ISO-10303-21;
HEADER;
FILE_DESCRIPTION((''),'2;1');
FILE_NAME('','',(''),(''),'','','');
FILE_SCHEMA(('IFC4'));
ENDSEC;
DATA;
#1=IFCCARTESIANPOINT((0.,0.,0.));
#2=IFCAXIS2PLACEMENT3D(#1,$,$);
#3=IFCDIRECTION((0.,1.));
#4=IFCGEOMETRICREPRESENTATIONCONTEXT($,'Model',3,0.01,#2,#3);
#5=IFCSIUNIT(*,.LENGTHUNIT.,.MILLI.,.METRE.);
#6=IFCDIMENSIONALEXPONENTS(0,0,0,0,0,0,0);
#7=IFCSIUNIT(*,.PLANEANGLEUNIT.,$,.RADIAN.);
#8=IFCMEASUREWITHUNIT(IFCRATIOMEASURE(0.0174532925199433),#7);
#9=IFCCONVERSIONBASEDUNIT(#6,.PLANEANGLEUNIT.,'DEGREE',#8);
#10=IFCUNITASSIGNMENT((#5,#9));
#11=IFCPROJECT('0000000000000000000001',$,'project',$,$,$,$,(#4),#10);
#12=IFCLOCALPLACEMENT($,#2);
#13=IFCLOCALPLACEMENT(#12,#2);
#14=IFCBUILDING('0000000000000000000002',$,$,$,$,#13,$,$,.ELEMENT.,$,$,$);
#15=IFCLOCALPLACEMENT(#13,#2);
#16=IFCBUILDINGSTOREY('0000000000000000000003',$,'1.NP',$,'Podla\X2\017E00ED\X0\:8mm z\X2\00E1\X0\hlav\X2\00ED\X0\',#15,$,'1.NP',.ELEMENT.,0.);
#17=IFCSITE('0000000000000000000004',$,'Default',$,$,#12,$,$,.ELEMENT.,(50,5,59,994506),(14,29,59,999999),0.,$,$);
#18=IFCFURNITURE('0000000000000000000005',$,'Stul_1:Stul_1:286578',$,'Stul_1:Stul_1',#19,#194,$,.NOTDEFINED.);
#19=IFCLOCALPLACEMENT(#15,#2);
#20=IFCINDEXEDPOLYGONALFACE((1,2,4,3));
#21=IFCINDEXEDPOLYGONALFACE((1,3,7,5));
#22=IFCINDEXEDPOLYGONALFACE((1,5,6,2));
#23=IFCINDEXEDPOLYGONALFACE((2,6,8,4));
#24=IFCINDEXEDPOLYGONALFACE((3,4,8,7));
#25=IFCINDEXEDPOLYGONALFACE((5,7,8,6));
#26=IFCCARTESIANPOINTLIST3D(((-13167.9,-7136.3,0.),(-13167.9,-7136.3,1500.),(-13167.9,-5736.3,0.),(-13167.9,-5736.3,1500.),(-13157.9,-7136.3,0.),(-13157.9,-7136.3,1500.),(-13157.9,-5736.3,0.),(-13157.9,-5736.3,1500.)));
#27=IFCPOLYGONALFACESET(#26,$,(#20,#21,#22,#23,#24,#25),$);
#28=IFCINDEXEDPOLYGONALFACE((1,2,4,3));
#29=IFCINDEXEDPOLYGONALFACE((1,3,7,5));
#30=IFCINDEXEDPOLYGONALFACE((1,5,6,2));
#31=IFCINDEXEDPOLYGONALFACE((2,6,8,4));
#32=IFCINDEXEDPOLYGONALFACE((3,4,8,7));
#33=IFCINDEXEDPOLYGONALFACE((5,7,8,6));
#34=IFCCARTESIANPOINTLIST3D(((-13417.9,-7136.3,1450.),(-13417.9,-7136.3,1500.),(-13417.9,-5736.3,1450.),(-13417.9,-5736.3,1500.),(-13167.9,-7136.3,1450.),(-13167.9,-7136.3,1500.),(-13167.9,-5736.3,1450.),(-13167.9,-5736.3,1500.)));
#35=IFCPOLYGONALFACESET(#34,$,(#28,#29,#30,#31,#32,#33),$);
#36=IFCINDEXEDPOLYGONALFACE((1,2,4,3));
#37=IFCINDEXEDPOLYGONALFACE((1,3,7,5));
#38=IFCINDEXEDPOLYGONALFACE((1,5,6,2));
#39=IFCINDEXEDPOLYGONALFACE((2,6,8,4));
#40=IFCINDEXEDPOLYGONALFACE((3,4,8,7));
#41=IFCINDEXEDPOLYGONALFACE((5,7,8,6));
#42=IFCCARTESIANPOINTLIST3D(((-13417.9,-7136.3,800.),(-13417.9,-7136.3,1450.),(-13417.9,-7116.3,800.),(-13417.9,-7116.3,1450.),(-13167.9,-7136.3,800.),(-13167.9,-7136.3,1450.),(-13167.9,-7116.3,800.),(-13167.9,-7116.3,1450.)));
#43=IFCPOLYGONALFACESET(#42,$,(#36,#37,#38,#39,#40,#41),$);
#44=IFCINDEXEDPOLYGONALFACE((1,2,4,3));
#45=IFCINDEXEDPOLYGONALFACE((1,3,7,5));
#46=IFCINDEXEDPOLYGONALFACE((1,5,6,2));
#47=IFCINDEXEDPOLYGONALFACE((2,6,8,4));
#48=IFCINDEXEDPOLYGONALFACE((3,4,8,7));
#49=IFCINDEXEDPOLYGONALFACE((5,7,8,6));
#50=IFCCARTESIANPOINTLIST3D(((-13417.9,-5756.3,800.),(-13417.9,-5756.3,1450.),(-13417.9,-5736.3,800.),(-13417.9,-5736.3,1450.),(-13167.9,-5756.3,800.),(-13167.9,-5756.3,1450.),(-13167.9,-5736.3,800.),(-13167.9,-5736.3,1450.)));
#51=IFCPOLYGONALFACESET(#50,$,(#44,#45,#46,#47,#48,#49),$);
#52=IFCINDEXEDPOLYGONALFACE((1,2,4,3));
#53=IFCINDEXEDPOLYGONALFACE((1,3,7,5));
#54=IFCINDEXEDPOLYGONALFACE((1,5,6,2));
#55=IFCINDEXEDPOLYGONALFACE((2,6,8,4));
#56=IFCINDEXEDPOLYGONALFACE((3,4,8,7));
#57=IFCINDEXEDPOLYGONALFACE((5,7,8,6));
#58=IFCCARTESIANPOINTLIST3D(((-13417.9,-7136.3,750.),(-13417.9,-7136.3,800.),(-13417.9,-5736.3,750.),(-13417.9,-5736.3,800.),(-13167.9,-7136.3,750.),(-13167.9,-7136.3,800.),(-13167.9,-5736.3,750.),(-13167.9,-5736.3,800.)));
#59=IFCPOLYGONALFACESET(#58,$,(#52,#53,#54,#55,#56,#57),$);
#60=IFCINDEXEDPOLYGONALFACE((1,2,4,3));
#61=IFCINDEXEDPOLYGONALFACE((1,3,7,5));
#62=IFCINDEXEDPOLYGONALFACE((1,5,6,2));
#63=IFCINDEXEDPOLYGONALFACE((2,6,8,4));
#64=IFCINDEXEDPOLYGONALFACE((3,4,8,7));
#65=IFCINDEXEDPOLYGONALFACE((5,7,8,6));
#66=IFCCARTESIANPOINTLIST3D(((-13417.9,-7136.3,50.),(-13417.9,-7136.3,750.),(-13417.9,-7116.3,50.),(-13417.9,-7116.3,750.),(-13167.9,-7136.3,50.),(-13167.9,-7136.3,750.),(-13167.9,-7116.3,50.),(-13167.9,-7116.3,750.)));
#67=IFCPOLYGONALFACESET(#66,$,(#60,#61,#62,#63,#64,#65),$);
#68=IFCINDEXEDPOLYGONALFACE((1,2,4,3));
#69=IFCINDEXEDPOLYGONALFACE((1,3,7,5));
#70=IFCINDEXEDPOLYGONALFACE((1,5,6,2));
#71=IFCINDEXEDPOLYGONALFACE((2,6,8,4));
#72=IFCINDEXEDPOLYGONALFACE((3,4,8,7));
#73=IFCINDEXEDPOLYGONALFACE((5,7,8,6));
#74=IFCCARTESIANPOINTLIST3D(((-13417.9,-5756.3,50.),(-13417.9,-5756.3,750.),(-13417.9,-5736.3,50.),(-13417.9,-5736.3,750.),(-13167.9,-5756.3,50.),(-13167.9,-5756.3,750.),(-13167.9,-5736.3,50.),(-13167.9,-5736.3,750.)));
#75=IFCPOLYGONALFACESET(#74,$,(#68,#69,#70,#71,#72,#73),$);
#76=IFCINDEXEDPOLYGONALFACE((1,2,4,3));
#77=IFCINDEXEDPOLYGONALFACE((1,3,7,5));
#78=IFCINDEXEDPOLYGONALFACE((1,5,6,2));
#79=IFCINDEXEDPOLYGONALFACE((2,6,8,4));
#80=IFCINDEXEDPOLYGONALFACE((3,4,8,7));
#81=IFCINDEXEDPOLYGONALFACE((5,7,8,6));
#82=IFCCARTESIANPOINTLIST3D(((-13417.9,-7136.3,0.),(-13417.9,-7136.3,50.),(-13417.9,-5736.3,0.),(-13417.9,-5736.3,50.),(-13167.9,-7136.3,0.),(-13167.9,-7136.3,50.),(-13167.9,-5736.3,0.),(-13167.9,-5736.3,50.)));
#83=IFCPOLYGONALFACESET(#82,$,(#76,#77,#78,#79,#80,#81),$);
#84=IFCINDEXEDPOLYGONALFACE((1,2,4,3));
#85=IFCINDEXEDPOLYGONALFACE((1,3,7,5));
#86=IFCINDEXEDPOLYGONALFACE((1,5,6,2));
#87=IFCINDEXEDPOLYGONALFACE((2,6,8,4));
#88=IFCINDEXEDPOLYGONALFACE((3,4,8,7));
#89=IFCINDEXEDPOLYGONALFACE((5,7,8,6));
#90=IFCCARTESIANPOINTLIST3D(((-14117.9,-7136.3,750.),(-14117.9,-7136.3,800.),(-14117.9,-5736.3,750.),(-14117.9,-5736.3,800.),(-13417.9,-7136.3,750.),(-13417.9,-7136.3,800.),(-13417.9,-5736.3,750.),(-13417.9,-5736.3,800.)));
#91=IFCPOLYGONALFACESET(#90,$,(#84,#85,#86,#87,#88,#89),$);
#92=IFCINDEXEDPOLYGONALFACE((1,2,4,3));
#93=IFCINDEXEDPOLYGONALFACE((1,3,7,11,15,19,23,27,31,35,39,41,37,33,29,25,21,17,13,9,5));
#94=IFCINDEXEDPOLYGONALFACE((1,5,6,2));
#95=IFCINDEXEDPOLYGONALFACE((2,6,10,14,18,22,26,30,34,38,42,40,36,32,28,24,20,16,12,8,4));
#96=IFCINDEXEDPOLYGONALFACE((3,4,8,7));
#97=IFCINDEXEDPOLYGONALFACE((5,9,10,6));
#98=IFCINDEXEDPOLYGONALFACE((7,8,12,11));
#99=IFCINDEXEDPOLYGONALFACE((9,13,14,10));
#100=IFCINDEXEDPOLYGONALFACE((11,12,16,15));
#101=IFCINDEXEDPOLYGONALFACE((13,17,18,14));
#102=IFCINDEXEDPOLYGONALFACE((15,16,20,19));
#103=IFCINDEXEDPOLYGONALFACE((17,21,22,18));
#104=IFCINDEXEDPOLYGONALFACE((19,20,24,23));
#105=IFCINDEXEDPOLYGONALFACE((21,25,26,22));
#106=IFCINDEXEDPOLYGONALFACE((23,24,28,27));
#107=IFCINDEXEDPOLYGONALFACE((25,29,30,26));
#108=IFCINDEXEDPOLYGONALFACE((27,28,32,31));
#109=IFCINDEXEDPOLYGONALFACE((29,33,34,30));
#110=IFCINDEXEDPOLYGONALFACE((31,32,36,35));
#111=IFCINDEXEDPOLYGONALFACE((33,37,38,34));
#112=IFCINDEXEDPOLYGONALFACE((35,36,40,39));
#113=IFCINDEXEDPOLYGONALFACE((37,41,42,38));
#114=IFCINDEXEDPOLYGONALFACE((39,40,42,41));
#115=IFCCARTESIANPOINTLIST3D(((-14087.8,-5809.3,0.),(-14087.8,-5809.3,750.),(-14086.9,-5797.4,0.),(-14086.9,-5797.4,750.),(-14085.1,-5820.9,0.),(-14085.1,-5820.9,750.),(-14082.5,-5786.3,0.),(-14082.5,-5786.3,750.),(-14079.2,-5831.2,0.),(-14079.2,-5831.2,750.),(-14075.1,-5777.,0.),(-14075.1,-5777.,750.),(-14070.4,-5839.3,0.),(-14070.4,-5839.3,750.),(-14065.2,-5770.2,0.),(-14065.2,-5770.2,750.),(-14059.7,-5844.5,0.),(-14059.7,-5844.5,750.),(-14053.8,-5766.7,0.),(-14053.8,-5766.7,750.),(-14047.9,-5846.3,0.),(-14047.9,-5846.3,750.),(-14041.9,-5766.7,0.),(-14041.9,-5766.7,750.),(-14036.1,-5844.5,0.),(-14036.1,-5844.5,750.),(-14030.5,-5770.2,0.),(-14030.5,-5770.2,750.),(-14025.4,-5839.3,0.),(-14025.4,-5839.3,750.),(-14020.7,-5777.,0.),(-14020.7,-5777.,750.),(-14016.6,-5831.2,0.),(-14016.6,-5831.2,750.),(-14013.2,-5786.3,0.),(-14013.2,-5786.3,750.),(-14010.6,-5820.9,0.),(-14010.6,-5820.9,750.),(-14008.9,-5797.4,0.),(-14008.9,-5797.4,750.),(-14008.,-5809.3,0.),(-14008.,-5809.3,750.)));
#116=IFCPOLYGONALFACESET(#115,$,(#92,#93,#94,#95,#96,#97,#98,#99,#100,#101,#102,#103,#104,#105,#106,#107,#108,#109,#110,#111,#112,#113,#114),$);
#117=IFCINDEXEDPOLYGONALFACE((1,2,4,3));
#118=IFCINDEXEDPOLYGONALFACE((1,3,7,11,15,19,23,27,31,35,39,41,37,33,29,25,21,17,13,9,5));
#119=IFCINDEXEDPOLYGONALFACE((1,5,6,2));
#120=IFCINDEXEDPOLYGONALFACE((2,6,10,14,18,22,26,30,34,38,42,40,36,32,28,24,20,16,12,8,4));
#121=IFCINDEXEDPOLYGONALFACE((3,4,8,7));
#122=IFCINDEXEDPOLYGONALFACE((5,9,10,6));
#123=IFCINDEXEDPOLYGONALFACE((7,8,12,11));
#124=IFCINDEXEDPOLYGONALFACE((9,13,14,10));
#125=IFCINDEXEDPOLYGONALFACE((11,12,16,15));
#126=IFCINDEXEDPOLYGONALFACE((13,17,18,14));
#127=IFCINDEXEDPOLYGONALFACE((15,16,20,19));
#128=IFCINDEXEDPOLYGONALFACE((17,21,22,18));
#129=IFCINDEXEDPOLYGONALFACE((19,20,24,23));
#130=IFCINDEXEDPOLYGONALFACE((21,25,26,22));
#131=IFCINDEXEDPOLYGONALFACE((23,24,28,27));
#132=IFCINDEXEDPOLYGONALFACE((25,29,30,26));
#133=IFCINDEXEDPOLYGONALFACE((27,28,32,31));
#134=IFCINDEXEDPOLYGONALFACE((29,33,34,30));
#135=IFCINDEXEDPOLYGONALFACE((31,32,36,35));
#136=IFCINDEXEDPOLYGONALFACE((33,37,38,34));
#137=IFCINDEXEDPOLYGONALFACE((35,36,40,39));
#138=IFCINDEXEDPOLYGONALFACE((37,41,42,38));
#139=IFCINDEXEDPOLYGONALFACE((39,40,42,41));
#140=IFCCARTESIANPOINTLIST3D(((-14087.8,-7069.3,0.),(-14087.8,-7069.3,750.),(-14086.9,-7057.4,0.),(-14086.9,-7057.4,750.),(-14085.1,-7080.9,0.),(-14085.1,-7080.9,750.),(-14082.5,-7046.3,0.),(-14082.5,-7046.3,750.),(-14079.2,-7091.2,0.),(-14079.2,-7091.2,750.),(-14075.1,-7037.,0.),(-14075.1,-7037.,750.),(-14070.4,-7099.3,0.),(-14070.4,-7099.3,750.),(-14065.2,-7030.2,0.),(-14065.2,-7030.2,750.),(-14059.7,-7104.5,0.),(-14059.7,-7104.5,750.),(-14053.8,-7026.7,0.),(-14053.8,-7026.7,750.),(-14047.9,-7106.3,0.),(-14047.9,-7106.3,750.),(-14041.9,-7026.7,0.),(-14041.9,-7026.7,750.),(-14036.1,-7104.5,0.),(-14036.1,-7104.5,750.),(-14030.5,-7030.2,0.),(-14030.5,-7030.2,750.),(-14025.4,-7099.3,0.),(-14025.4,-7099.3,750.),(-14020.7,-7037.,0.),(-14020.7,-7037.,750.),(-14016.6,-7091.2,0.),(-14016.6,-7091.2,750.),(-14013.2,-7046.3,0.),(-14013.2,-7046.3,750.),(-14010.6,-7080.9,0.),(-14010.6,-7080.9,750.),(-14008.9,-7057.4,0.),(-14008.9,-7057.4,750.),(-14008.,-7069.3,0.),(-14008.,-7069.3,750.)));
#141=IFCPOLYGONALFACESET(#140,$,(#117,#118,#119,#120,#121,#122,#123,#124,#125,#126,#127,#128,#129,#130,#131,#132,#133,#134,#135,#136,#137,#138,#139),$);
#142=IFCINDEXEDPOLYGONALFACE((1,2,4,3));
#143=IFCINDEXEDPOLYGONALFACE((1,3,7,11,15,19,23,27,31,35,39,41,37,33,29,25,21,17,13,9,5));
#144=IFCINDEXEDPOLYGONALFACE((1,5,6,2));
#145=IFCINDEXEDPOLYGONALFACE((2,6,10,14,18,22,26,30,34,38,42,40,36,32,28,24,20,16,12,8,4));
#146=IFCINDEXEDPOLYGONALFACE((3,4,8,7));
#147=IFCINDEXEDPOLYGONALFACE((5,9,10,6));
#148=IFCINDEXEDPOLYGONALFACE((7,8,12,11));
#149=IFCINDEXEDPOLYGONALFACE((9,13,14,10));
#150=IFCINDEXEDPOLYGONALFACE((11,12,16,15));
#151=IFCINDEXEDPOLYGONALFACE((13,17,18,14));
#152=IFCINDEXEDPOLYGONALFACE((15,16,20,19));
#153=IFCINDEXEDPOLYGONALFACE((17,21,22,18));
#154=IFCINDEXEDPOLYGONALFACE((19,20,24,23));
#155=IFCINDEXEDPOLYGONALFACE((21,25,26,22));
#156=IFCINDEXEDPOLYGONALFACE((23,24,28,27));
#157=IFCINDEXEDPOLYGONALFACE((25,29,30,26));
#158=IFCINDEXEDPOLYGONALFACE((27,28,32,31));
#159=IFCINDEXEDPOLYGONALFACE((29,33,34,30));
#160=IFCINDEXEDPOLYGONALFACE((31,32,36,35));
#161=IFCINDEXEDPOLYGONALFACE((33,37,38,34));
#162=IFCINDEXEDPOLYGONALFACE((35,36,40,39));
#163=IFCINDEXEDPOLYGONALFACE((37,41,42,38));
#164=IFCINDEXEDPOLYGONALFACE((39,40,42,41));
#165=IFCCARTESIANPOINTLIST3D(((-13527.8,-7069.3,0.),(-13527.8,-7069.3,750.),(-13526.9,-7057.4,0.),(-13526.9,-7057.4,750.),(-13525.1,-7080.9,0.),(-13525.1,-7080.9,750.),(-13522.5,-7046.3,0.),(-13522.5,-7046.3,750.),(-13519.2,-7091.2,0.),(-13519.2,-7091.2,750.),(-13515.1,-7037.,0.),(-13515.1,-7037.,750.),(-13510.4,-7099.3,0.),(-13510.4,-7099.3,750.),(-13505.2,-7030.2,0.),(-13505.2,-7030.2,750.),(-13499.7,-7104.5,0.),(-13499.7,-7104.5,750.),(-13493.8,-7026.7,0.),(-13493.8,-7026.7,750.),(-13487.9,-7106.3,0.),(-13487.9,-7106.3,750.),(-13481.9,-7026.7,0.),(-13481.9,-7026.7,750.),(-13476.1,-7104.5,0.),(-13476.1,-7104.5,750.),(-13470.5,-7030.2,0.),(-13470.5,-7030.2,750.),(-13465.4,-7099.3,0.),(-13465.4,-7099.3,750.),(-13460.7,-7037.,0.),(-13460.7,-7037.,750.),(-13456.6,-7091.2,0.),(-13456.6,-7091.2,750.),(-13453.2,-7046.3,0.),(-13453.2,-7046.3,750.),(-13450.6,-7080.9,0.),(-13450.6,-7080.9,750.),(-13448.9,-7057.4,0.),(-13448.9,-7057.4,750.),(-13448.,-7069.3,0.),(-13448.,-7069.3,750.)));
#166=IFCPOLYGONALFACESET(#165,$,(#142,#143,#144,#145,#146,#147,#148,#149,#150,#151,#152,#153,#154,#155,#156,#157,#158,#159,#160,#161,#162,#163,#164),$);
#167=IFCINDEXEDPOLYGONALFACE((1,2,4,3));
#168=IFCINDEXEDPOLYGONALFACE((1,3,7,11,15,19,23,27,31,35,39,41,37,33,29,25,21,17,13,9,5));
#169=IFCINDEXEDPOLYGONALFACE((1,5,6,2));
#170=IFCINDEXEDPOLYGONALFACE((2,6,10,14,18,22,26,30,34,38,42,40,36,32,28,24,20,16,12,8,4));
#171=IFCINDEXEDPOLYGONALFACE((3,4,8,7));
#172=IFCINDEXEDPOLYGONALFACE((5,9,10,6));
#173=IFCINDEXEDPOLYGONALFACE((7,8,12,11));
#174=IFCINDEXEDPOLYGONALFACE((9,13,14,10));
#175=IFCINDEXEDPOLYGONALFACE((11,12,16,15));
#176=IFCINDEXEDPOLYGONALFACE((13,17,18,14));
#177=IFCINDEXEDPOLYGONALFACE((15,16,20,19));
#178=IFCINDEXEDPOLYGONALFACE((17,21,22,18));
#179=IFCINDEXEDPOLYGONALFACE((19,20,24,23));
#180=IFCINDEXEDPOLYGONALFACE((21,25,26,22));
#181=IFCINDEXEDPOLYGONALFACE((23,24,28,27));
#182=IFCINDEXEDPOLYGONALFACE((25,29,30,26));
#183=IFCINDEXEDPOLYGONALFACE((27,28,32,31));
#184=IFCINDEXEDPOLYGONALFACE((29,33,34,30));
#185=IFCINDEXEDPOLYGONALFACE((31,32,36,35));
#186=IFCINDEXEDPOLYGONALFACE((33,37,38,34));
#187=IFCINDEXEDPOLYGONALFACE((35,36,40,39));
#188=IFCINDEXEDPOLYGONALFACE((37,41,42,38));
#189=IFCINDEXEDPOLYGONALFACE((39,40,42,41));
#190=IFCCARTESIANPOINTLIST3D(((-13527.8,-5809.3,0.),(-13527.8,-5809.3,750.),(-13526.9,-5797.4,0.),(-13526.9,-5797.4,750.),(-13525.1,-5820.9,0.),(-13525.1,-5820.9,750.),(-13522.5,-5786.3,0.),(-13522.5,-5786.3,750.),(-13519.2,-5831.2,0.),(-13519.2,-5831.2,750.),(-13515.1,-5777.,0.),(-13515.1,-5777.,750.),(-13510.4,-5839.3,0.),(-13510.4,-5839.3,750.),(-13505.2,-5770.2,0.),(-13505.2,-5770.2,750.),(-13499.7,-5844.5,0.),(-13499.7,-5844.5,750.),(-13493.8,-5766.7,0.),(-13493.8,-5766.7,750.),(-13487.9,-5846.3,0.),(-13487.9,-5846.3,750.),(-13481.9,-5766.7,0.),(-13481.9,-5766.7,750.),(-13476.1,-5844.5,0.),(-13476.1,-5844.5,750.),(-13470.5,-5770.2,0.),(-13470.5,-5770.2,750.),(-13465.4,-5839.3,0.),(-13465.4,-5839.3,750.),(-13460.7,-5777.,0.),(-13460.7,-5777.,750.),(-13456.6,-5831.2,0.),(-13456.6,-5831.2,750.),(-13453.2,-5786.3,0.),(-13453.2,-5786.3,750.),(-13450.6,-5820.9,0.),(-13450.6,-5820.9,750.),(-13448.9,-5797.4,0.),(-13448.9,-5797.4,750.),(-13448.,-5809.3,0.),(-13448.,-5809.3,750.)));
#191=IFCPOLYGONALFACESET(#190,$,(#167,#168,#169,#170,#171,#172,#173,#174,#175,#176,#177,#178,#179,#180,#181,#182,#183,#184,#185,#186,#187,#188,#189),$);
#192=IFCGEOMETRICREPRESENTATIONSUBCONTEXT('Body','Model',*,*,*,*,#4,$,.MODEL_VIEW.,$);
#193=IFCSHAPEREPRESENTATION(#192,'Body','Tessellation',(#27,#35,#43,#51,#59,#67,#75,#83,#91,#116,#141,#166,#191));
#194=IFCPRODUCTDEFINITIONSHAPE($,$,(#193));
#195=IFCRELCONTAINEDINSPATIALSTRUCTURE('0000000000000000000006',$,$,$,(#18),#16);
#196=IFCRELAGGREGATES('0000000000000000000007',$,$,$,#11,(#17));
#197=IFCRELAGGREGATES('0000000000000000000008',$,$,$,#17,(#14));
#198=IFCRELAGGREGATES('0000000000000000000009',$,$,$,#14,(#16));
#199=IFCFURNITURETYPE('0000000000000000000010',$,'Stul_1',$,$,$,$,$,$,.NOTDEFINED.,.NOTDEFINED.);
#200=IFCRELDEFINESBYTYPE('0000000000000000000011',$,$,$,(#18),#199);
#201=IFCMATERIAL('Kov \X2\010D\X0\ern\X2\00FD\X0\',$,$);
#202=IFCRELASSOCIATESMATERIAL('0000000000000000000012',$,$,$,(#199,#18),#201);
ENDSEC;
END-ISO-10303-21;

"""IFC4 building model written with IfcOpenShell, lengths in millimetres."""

from ifc_helpers import new_model, entity, si_unit, converted_unit, direction, frame, frame_2d, origin, origin_2d_with_axis, place, context, subcontext, project, spatial, rectangle, circle, extrude, source, transform, mapped, material, type_object, type_shapes, element, save


model = new_model("IFC4")

# Units and contexts
model_context = context("Model", 3, precision=0.01, world=origin(), true_north=direction((0.0, 1.0)))
body_context = subcontext(model_context, "Body", "Model", "MODEL_VIEW")
ifc_project = project(units=[si_unit("LENGTHUNIT", "METRE", prefix="MILLI"), converted_unit("PLANEANGLEUNIT", "DEGREE", entity("IfcRatioMeasure", 0.0174532925199433), si_unit("PLANEANGLEUNIT", "RADIAN"), dimensions=[0, 0, 0, 0, 0, 0, 0])], contexts=[model_context])

# Site, building, storey
site_placement = place(None, origin())
site = spatial("IfcSite", under=ifc_project, at=site_placement, Name="Default", CompositionType="ELEMENT", RefLatitude=(50, 5, 59, 994506), RefLongitude=(14, 29, 59, 999999), RefElevation=0.0)
building_placement = place(site_placement, origin())
building = spatial("IfcBuilding", under=site, at=building_placement, CompositionType="ELEMENT")
storey_placement = place(building_placement, origin())
storey = spatial("IfcBuildingStorey", under=building, at=storey_placement, Name="1.NP", ObjectType="Podlaží:8mm záhlaví", LongName="1.NP", CompositionType="ELEMENT", Elevation=0.0)

# Furniture
ifc_material_1 = material(Name="Kov černý")
furniture_type = type_object("IfcFurnitureType", Name="Stul_1", AssemblyPlace="NOTDEFINED", PredefinedType="NOTDEFINED", material=ifc_material_1)
shared_shape_1 = source(origin(), body_context, "Body", "SweptSolid", [
    extrude(rectangle(XDim=1400.0, YDim=10.0, at=origin_2d_with_axis()), frame((0.0, 605.0, 0.0), z_axis=(0.0, 0.0, 1.0), x_axis=(-1.0, 0.0, 0.0)), (0.0, 0.0, 1.0), 1500.0),
    extrude(rectangle(XDim=1400.0, YDim=250.0, at=frame_2d((0.0, 0.0), x_axis=(1.0, 0.0))), frame((0.0, 475.0, 1450.0), z_axis=(0.0, 0.0, 1.0), x_axis=(-1.0, 0.0, 0.0)), (0.0, 0.0, 1.0), 50.0),
    extrude(rectangle(XDim=20.0, YDim=250.0, at=origin_2d_with_axis()), frame((690.0, 475.0, 800.0), z_axis=(0.0, 0.0, 1.0), x_axis=(-1.0, 0.0, 0.0)), (0.0, 0.0, 1.0), 650.0),
    extrude(rectangle(XDim=20.0, YDim=250.0, at=frame_2d((0.0, 0.0), x_axis=(1.0, 0.0))), frame((-690.0, 475.0, 800.0), z_axis=(0.0, 0.0, 1.0), x_axis=(-1.0, 0.0, 0.0)), (0.0, 0.0, 1.0), 650.0),
    extrude(rectangle(XDim=1400.0, YDim=250.0, at=origin_2d_with_axis()), frame((0.0, 475.0, 750.0), z_axis=(0.0, 0.0, 1.0), x_axis=(-1.0, 0.0, 0.0)), (0.0, 0.0, 1.0), 50.0),
    extrude(rectangle(XDim=20.0, YDim=250.0, at=origin_2d_with_axis()), frame((690.0, 475.0, 50.0), z_axis=(0.0, 0.0, 1.0), x_axis=(-1.0, 0.0, 0.0)), (0.0, 0.0, 1.0), 700.0),
    extrude(rectangle(XDim=20.0, YDim=250.0, at=frame_2d((0.0, 0.0), x_axis=(1.0, 0.0))), frame((-690.0, 475.0, 50.0), z_axis=(0.0, 0.0, 1.0), x_axis=(-1.0, 0.0, 0.0)), (0.0, 0.0, 1.0), 700.0),
    extrude(rectangle(XDim=1400.0, YDim=250.0, at=origin_2d_with_axis()), frame((0.0, 475.0, 0.0), z_axis=(0.0, 0.0, 1.0), x_axis=(-1.0, 0.0, 0.0)), (0.0, 0.0, 1.0), 50.0),
    extrude(rectangle(XDim=1400.0, YDim=700.0, at=origin_2d_with_axis()), frame((0.0, 0.0, 750.0), z_axis=(0.0, 0.0, 1.0), x_axis=(-1.0, 0.0, 0.0)), (0.0, 0.0, 1.0), 50.0),
    extrude(circle(Radius=40.0, at=frame_2d((0.0, 0.0), x_axis=(1.0, 0.0))), frame((-630.0, -280.0, 0.0)), (0.0, 0.0, 1.0), 750.0),
    extrude(circle(Radius=40.0, at=frame_2d((0.0, 0.0), x_axis=(1.0, 0.0))), frame((630.0, -280.0, 0.0)), (0.0, 0.0, 1.0), 750.0),
    extrude(circle(Radius=40.0, at=frame_2d((0.0, 0.0), x_axis=(1.0, 0.0))), frame((630.0, 280.0, 0.0)), (0.0, 0.0, 1.0), 750.0),
    extrude(circle(Radius=40.0, at=frame_2d((0.0, 0.0), x_axis=(1.0, 0.0))), frame((-630.0, 280.0, 0.0)), (0.0, 0.0, 1.0), 750.0),
])
type_shapes(furniture_type, [shared_shape_1])
for number, where, z_axis, x_axis, name in (
    (1, (-13767.9, -6436.3, 0.0), (0.0, 0.0, 1.0), (0.0, -1.0, 0.0), "Stul_1:Stul_1:286578"),
):
    element("IfcFurniture", number, at=place(storey_placement, frame(where, z_axis=z_axis, x_axis=x_axis)), inside=storey, type_object=furniture_type, material=ifc_material_1, Name=name, ObjectType="Stul_1:Stul_1", PredefinedType="NOTDEFINED", context=body_context, shape_type="MappedRepresentation", body=[
        mapped(shared_shape_1, transform((0.0, 0.0, 0.0), scale=1.0)),
    ])

save(model, "model.ifc")
